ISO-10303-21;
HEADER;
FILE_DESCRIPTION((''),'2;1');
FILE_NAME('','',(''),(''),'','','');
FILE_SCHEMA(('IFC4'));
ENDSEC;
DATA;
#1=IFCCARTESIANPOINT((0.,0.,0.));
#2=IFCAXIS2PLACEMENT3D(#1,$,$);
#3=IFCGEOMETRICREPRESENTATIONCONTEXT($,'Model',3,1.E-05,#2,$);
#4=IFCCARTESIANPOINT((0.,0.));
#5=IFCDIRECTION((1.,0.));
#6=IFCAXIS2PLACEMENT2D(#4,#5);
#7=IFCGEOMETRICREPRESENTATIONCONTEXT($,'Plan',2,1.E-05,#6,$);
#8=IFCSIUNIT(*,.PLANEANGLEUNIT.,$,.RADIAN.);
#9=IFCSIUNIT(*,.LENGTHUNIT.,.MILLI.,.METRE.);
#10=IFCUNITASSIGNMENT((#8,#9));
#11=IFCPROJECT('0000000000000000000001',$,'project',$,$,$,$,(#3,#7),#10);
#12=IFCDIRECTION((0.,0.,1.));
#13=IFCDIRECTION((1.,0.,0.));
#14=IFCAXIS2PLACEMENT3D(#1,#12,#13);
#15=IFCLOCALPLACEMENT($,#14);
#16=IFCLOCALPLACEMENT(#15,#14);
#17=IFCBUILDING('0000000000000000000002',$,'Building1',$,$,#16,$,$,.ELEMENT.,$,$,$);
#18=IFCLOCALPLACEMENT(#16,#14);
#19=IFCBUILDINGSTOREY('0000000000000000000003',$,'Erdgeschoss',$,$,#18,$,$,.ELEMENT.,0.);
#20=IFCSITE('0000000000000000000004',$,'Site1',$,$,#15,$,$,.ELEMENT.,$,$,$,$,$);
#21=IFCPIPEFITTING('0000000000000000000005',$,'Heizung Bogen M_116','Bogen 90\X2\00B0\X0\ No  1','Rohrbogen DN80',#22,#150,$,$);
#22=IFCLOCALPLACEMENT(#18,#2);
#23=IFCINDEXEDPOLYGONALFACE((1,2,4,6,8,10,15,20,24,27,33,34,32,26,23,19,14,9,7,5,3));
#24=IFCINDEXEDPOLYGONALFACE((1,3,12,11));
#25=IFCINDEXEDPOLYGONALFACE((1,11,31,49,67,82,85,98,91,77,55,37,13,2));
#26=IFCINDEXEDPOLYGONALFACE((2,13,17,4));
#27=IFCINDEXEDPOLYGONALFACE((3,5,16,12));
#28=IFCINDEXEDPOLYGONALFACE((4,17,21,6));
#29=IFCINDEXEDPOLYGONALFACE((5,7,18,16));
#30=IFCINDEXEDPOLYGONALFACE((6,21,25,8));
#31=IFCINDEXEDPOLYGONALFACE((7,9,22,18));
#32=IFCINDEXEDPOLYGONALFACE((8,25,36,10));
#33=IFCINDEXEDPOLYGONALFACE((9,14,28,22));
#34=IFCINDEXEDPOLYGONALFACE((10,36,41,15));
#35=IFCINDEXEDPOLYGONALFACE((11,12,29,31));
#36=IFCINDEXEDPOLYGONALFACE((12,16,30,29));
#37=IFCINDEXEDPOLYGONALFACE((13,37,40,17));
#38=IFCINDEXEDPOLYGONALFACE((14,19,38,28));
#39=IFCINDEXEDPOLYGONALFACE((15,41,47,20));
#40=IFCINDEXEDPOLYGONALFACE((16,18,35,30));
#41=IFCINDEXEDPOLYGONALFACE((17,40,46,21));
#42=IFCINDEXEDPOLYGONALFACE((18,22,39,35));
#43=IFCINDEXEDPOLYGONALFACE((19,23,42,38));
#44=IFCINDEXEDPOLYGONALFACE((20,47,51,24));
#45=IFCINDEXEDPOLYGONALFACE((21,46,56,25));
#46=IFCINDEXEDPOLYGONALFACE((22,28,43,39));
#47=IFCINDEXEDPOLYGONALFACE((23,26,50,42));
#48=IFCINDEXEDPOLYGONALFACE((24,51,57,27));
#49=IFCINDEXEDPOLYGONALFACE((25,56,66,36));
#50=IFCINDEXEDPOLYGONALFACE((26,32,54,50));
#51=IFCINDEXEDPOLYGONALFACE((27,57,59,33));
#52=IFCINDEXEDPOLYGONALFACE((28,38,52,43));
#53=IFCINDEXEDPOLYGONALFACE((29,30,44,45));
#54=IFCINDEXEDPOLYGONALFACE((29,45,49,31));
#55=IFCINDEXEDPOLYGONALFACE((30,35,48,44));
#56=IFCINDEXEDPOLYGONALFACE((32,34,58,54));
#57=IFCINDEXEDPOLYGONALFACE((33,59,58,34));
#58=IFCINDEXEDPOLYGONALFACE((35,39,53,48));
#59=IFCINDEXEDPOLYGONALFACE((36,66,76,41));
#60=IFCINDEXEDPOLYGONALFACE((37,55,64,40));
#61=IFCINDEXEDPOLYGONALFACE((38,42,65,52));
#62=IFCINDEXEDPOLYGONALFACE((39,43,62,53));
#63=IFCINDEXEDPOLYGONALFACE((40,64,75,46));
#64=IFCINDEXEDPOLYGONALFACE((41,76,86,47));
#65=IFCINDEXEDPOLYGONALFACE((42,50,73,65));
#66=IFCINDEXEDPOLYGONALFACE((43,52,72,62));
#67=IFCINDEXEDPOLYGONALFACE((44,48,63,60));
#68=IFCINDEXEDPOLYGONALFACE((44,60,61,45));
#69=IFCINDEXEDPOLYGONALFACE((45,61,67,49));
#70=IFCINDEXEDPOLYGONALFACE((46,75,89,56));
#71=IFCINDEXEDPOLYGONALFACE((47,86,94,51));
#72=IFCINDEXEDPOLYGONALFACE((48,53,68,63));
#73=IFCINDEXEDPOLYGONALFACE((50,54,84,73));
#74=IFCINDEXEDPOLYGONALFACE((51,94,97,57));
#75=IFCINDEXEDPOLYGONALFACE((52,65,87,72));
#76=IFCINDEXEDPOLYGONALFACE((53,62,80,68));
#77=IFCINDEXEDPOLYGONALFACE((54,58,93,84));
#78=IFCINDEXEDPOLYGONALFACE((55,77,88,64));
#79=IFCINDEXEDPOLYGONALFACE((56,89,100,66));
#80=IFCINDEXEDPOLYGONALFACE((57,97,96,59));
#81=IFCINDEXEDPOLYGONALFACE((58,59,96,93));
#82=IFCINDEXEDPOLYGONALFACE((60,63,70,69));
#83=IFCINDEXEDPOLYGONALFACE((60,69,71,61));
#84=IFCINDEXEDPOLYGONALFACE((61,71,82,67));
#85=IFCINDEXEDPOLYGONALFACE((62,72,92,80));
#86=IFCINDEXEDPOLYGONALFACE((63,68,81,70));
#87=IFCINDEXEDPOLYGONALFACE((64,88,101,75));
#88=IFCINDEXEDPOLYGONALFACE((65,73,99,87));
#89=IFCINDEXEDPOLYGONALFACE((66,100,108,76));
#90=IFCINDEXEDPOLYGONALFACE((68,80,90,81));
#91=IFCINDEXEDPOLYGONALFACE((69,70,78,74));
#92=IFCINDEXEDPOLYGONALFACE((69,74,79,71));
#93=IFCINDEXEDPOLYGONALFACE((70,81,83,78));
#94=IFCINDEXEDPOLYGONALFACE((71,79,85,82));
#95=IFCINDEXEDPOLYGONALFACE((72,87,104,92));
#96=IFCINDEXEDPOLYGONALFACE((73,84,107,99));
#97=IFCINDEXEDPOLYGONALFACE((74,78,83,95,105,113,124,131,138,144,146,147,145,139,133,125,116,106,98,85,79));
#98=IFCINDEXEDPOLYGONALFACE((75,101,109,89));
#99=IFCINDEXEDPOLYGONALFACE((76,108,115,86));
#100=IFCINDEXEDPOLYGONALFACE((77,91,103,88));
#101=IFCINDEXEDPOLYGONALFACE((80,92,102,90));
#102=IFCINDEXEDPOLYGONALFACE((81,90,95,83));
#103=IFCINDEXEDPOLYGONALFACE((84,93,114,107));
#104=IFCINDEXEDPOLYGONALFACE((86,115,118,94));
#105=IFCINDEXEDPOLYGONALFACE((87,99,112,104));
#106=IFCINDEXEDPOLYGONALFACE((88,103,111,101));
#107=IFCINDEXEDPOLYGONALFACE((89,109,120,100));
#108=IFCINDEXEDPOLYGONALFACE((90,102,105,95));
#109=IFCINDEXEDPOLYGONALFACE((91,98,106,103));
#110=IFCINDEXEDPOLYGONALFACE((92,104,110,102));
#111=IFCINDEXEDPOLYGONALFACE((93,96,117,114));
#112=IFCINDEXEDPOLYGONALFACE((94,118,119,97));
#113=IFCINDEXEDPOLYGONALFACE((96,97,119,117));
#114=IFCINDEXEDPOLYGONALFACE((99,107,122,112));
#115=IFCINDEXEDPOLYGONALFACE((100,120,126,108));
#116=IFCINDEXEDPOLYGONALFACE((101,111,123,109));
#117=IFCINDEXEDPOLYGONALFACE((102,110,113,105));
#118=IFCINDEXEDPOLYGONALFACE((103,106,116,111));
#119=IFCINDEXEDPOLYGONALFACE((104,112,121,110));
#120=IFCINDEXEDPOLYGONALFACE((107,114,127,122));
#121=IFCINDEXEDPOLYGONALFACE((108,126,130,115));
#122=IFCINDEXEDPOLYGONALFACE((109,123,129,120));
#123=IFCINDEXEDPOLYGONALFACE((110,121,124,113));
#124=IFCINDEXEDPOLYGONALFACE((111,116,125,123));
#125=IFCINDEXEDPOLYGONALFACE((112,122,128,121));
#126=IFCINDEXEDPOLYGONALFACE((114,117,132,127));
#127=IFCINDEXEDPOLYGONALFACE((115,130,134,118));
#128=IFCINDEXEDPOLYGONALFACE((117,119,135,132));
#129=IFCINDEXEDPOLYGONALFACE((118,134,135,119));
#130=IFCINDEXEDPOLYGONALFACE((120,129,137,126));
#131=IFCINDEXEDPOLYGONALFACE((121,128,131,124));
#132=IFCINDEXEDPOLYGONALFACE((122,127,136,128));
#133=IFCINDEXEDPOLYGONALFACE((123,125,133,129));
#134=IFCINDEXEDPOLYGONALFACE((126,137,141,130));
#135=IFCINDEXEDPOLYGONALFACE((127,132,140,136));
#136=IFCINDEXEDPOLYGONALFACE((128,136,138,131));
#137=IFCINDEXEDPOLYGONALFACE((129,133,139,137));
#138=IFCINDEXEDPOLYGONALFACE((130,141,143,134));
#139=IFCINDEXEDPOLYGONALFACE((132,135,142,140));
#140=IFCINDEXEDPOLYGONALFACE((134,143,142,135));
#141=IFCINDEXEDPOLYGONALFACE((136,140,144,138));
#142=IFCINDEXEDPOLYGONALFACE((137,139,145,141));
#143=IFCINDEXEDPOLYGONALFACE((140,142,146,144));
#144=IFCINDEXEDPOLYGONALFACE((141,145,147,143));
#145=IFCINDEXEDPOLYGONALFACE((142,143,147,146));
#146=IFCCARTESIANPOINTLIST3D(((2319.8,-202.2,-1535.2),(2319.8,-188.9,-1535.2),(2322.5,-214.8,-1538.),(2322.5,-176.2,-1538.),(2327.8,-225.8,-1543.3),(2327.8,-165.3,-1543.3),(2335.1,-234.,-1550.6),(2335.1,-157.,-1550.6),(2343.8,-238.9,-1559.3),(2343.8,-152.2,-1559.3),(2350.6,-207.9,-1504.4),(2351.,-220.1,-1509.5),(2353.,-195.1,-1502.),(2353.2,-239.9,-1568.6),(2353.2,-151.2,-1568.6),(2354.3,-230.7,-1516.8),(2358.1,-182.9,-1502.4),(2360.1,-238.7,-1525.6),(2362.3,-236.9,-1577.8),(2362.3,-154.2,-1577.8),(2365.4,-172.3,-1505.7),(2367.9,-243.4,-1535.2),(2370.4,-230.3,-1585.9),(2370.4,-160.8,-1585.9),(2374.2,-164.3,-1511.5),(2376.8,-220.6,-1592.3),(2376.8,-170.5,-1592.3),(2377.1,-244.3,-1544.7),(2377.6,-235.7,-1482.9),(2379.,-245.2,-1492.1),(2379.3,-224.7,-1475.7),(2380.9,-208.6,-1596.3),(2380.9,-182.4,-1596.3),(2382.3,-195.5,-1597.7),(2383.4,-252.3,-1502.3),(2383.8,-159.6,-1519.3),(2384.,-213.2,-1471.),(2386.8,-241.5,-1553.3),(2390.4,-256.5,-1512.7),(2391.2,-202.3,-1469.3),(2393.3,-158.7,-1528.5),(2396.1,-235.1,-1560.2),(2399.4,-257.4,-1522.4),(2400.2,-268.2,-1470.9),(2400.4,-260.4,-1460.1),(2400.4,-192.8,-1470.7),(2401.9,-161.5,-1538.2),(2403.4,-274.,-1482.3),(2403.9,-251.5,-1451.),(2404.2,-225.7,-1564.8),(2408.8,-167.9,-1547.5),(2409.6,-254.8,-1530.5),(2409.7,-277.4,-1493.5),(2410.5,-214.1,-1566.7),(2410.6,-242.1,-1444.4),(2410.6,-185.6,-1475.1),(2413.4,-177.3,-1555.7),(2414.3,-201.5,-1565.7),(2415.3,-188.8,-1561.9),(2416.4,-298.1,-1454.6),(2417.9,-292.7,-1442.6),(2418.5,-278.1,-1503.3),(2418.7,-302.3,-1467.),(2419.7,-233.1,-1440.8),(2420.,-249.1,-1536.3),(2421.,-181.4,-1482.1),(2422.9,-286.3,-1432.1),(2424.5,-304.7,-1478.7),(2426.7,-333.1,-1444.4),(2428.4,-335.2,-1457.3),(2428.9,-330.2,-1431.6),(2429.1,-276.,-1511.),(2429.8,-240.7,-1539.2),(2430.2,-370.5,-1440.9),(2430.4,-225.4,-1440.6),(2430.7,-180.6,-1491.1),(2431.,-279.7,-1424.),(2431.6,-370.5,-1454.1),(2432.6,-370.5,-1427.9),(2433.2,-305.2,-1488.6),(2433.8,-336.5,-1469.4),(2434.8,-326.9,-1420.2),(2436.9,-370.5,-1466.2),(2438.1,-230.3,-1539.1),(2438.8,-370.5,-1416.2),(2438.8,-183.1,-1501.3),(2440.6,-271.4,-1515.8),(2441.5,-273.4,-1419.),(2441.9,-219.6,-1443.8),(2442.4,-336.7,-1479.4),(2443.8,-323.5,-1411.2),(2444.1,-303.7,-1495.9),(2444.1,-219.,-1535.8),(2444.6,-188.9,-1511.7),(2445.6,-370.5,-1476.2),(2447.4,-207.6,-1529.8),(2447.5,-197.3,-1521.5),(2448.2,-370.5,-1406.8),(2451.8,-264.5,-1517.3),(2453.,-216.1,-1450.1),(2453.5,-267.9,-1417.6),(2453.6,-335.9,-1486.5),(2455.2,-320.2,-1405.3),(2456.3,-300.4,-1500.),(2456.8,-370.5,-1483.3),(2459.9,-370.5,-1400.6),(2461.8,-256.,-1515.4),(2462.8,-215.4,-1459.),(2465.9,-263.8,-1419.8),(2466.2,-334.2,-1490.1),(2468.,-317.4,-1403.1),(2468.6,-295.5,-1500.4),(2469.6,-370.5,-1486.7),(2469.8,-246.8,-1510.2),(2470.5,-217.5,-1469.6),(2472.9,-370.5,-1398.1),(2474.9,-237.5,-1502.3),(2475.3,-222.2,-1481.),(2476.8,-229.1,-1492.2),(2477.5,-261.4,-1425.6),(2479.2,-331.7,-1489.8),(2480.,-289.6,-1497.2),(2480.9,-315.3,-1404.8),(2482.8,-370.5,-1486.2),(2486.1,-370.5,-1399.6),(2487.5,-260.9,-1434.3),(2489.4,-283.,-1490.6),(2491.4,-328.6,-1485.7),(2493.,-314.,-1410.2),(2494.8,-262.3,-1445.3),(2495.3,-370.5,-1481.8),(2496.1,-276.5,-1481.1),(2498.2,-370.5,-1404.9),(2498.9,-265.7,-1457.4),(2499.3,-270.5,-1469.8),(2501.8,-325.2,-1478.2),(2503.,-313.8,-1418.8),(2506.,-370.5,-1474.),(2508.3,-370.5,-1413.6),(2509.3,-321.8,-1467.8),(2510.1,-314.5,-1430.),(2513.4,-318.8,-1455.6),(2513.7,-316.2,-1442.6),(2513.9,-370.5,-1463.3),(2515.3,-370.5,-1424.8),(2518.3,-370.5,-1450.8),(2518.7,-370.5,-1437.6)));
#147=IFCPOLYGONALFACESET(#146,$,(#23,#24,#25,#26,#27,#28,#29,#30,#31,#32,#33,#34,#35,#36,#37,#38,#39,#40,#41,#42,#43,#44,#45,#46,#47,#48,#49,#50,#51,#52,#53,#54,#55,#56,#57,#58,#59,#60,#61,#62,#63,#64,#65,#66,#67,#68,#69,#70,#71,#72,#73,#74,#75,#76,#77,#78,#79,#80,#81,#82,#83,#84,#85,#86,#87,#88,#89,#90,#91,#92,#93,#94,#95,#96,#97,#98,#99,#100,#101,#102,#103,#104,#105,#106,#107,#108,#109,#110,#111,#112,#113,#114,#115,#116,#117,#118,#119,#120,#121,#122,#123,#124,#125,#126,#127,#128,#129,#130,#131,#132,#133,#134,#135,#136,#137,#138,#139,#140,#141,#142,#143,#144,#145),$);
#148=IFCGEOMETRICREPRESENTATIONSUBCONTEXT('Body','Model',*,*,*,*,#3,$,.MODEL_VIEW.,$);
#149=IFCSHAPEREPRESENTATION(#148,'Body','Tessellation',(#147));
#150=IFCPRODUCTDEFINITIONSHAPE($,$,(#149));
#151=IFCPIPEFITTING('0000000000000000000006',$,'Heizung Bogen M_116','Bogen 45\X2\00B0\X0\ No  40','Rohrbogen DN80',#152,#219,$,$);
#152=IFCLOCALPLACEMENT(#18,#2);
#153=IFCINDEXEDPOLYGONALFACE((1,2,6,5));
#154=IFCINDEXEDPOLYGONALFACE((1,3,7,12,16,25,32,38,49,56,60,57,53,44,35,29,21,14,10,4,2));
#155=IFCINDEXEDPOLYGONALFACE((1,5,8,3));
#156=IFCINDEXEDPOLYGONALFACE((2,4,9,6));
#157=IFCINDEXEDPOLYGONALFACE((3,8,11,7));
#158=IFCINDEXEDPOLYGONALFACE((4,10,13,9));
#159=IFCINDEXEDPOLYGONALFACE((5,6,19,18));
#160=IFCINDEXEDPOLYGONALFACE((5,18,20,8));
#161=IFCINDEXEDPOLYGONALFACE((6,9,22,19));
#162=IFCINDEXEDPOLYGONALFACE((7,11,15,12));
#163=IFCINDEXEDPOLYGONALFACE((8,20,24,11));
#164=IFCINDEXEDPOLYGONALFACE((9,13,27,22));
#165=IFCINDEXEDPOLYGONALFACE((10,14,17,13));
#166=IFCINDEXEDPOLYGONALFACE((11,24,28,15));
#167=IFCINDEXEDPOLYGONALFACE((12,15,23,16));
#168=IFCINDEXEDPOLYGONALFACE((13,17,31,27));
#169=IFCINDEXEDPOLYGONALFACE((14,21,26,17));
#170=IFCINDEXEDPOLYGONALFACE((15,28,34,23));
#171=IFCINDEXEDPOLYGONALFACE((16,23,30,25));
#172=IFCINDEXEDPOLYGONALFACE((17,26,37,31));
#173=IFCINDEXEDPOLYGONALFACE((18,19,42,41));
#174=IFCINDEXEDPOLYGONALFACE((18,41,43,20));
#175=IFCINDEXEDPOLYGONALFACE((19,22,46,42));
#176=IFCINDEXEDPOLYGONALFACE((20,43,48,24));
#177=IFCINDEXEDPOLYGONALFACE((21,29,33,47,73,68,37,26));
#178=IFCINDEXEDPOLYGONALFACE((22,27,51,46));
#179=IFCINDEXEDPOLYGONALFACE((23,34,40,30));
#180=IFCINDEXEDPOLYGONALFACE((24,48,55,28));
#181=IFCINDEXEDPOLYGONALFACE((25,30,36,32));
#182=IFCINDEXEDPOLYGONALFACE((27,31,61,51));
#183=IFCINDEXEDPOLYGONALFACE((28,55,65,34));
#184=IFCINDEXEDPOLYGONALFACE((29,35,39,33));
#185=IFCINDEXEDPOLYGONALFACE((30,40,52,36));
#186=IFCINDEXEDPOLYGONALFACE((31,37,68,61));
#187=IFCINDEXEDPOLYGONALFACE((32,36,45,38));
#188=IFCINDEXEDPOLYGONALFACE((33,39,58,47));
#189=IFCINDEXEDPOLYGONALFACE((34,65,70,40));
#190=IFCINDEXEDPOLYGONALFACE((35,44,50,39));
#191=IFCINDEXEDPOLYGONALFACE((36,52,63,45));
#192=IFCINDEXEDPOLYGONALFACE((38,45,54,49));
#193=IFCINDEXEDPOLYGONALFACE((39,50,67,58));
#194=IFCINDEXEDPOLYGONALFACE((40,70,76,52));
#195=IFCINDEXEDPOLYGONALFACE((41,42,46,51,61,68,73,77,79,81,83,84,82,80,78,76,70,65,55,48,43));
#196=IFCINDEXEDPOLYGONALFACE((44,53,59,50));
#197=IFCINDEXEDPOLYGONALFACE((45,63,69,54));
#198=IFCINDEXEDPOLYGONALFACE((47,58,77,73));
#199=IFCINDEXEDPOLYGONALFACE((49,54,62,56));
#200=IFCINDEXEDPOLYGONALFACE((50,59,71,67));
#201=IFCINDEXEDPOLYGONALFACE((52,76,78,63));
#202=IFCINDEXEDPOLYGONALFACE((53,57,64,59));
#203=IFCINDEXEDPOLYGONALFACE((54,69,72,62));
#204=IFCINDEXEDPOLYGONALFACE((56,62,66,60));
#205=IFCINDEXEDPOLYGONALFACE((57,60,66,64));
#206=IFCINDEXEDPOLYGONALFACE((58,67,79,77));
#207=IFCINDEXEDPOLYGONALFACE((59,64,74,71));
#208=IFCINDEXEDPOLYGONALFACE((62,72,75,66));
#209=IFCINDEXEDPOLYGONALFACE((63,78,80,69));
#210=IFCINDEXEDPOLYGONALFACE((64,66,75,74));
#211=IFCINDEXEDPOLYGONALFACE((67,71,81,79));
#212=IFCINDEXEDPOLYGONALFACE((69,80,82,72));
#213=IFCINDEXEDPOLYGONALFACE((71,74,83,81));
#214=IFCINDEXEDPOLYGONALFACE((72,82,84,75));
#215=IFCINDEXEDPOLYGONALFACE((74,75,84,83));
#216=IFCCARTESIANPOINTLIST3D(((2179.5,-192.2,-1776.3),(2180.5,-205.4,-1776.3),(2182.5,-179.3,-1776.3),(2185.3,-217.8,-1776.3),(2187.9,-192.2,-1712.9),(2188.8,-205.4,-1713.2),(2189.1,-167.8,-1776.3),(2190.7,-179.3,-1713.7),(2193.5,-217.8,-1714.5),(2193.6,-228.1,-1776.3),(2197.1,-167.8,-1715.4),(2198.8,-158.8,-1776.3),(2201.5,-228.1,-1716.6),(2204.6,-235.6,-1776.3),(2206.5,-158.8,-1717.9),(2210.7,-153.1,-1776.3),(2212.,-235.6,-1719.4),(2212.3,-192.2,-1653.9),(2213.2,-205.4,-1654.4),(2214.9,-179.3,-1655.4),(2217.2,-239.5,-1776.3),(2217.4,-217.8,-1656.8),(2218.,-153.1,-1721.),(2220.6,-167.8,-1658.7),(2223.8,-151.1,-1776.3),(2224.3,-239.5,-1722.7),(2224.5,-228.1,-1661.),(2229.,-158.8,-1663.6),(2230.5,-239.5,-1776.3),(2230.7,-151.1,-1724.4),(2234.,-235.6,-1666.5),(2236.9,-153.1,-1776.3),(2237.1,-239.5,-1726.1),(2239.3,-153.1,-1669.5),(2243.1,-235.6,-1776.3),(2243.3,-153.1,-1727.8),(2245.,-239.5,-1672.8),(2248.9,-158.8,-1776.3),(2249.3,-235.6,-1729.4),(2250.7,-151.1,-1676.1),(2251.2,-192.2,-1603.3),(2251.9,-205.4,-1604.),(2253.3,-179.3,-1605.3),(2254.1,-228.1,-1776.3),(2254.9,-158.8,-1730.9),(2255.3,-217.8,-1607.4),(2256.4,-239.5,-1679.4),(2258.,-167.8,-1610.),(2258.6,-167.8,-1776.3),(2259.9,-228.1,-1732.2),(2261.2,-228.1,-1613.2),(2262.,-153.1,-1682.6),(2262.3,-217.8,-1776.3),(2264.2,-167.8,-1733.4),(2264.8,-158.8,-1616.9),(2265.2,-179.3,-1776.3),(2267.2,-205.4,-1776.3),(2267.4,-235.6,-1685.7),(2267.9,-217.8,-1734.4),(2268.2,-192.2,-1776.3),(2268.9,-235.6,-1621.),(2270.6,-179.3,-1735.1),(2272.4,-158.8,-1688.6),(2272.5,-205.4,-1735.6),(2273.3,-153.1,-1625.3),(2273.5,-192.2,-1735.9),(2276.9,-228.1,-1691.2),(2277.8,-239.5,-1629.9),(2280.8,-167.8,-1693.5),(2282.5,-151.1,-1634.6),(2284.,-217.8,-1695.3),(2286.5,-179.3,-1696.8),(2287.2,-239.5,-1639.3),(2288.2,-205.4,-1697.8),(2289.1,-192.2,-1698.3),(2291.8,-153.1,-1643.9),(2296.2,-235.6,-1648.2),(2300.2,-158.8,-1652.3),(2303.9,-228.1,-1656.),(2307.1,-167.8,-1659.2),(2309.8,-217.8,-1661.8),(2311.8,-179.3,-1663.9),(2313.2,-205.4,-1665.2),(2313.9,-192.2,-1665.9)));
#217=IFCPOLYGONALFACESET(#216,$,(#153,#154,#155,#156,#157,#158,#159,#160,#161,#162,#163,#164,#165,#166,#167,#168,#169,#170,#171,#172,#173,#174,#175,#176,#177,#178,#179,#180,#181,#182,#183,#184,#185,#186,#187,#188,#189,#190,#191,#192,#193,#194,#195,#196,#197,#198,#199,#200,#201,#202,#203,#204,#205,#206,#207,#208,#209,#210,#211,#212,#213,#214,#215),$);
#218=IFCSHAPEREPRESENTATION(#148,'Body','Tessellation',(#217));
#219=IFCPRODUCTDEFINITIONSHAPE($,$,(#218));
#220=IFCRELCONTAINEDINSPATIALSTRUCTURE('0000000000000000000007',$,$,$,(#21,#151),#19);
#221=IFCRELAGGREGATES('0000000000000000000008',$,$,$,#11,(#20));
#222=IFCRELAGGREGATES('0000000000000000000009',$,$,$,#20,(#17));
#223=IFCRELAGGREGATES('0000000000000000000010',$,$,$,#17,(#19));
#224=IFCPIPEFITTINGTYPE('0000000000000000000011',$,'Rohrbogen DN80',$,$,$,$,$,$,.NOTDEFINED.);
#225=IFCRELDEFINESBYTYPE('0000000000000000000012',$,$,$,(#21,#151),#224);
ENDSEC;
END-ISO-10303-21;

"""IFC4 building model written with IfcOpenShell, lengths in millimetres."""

from ifc_helpers import new_model, entity, si_unit, frame, origin, origin_with_axes, origin_2d_with_axis, place, context, subcontext, project, spatial, source, transform, mapped, type_object, element, save


model = new_model("IFC4")

# Units and contexts
model_context = context("Model", 3, precision=1e-05, world=origin())
plan_context = context("Plan", 2, precision=1e-05, world=origin_2d_with_axis())
body_context = subcontext(model_context, "Body", "Model", "MODEL_VIEW")
ifc_project = project(units=[si_unit("PLANEANGLEUNIT", "RADIAN"), si_unit("LENGTHUNIT", "METRE", prefix="MILLI")], contexts=[model_context, plan_context])

# Site, building, storey
site_placement = place(None, origin_with_axes())
site = spatial("IfcSite", under=ifc_project, at=site_placement, Name="Site1", CompositionType="ELEMENT")
building_placement = place(site_placement, origin_with_axes())
building = spatial("IfcBuilding", under=site, at=building_placement, Name="Building1", CompositionType="ELEMENT")
storey_placement = place(building_placement, origin_with_axes())
storey = spatial("IfcBuildingStorey", under=building, at=storey_placement, Name="Erdgeschoss", CompositionType="ELEMENT", Elevation=0.0)

# Pipe fittings
pipe_fitting_type_1 = type_object("IfcPipeFittingType", Name="Rohrbogen DN80", PredefinedType="NOTDEFINED")
shared_shape_1 = source(origin_with_axes(), body_context, "Body", "SolidModel", [
    entity("IfcRevolvedAreaSolid", entity("IfcCircleProfileDef", "AREA", None, entity("IfcAxis2Placement2D", entity("IfcCartesianPoint", [0.0, 0.0]), entity("IfcDirection", [1.0, 0.0])), 44.5), entity("IfcAxis2Placement3D", entity("IfcCartesianPoint", [-109.7, 46.2, -46.2]), entity("IfcDirection", [1.0, 0.0, 0.0]), entity("IfcDirection", [0.0, 0.707107, 0.707107])), entity("IfcAxis1Placement", entity("IfcCartesianPoint", [0.0, 175.0, 0.0]), entity("IfcDirection", [-1.0, 0.0, 0.0])), 1.570796),
])
pipe_fitting_1_placement = place(storey_placement, frame((2428.4, -260.8, -1488.7), z_axis=(0.0, 0.0, 1.0), x_axis=(1.0, 0.0, 0.0)))
element("IfcPipeFitting", 1, at=pipe_fitting_1_placement, inside=storey, type_object=pipe_fitting_type_1, Name="Heizung Bogen M_116", Description="Bogen 90° No  1", ObjectType="Rohrbogen DN80", context=body_context, shape_type="MappedRepresentation", body=[
    mapped(shared_shape_1, transform((0.0, 0.0, 0.0), x_axis=(0.0, 1.0, 0.0), y_axis=(1.0, 0.0, 0.0), z_axis=(0.0, 0.0, -1.0), scale=1.0)),
])
ifc_direction_1 = entity("IfcDirection", [-1.0, 0.0, 0.0])
shared_shape_2 = source(origin_with_axes(), body_context, "Body", "SolidModel", [
    entity("IfcRevolvedAreaSolid", entity("IfcCircleProfileDef", "AREA", None, entity("IfcAxis2Placement2D", entity("IfcCartesianPoint", [0.0, 0.0]), entity("IfcDirection", [1.0, 0.0])), 44.5), entity("IfcAxis2Placement3D", entity("IfcCartesianPoint", [79.5, 22.8, 0.0]), ifc_direction_1, entity("IfcDirection", [0.0, 0.0, -1.0])), entity("IfcAxis1Placement", entity("IfcCartesianPoint", [0.0, 200.4, 0.0]), ifc_direction_1), 0.785398),
])
pipe_fitting_2_placement = place(storey_placement, frame((2242.5, -195.5, -1706.9), z_axis=(0.0, 0.0, 1.0), x_axis=(1.0, 0.0, 0.0)))
element("IfcPipeFitting", 2, at=pipe_fitting_2_placement, inside=storey, type_object=pipe_fitting_type_1, Name="Heizung Bogen M_116", Description="Bogen 45° No  40", ObjectType="Rohrbogen DN80", context=body_context, shape_type="MappedRepresentation", body=[
    mapped(shared_shape_2, transform((0.0, 0.0, 0.0), x_axis=(0.707107, 0.0, 0.707107), y_axis=(-0.707107, 0.0, 0.707107), z_axis=(0.0, -1.0, 0.0), scale=1.0)),
])

save(model, "model.ifc")
